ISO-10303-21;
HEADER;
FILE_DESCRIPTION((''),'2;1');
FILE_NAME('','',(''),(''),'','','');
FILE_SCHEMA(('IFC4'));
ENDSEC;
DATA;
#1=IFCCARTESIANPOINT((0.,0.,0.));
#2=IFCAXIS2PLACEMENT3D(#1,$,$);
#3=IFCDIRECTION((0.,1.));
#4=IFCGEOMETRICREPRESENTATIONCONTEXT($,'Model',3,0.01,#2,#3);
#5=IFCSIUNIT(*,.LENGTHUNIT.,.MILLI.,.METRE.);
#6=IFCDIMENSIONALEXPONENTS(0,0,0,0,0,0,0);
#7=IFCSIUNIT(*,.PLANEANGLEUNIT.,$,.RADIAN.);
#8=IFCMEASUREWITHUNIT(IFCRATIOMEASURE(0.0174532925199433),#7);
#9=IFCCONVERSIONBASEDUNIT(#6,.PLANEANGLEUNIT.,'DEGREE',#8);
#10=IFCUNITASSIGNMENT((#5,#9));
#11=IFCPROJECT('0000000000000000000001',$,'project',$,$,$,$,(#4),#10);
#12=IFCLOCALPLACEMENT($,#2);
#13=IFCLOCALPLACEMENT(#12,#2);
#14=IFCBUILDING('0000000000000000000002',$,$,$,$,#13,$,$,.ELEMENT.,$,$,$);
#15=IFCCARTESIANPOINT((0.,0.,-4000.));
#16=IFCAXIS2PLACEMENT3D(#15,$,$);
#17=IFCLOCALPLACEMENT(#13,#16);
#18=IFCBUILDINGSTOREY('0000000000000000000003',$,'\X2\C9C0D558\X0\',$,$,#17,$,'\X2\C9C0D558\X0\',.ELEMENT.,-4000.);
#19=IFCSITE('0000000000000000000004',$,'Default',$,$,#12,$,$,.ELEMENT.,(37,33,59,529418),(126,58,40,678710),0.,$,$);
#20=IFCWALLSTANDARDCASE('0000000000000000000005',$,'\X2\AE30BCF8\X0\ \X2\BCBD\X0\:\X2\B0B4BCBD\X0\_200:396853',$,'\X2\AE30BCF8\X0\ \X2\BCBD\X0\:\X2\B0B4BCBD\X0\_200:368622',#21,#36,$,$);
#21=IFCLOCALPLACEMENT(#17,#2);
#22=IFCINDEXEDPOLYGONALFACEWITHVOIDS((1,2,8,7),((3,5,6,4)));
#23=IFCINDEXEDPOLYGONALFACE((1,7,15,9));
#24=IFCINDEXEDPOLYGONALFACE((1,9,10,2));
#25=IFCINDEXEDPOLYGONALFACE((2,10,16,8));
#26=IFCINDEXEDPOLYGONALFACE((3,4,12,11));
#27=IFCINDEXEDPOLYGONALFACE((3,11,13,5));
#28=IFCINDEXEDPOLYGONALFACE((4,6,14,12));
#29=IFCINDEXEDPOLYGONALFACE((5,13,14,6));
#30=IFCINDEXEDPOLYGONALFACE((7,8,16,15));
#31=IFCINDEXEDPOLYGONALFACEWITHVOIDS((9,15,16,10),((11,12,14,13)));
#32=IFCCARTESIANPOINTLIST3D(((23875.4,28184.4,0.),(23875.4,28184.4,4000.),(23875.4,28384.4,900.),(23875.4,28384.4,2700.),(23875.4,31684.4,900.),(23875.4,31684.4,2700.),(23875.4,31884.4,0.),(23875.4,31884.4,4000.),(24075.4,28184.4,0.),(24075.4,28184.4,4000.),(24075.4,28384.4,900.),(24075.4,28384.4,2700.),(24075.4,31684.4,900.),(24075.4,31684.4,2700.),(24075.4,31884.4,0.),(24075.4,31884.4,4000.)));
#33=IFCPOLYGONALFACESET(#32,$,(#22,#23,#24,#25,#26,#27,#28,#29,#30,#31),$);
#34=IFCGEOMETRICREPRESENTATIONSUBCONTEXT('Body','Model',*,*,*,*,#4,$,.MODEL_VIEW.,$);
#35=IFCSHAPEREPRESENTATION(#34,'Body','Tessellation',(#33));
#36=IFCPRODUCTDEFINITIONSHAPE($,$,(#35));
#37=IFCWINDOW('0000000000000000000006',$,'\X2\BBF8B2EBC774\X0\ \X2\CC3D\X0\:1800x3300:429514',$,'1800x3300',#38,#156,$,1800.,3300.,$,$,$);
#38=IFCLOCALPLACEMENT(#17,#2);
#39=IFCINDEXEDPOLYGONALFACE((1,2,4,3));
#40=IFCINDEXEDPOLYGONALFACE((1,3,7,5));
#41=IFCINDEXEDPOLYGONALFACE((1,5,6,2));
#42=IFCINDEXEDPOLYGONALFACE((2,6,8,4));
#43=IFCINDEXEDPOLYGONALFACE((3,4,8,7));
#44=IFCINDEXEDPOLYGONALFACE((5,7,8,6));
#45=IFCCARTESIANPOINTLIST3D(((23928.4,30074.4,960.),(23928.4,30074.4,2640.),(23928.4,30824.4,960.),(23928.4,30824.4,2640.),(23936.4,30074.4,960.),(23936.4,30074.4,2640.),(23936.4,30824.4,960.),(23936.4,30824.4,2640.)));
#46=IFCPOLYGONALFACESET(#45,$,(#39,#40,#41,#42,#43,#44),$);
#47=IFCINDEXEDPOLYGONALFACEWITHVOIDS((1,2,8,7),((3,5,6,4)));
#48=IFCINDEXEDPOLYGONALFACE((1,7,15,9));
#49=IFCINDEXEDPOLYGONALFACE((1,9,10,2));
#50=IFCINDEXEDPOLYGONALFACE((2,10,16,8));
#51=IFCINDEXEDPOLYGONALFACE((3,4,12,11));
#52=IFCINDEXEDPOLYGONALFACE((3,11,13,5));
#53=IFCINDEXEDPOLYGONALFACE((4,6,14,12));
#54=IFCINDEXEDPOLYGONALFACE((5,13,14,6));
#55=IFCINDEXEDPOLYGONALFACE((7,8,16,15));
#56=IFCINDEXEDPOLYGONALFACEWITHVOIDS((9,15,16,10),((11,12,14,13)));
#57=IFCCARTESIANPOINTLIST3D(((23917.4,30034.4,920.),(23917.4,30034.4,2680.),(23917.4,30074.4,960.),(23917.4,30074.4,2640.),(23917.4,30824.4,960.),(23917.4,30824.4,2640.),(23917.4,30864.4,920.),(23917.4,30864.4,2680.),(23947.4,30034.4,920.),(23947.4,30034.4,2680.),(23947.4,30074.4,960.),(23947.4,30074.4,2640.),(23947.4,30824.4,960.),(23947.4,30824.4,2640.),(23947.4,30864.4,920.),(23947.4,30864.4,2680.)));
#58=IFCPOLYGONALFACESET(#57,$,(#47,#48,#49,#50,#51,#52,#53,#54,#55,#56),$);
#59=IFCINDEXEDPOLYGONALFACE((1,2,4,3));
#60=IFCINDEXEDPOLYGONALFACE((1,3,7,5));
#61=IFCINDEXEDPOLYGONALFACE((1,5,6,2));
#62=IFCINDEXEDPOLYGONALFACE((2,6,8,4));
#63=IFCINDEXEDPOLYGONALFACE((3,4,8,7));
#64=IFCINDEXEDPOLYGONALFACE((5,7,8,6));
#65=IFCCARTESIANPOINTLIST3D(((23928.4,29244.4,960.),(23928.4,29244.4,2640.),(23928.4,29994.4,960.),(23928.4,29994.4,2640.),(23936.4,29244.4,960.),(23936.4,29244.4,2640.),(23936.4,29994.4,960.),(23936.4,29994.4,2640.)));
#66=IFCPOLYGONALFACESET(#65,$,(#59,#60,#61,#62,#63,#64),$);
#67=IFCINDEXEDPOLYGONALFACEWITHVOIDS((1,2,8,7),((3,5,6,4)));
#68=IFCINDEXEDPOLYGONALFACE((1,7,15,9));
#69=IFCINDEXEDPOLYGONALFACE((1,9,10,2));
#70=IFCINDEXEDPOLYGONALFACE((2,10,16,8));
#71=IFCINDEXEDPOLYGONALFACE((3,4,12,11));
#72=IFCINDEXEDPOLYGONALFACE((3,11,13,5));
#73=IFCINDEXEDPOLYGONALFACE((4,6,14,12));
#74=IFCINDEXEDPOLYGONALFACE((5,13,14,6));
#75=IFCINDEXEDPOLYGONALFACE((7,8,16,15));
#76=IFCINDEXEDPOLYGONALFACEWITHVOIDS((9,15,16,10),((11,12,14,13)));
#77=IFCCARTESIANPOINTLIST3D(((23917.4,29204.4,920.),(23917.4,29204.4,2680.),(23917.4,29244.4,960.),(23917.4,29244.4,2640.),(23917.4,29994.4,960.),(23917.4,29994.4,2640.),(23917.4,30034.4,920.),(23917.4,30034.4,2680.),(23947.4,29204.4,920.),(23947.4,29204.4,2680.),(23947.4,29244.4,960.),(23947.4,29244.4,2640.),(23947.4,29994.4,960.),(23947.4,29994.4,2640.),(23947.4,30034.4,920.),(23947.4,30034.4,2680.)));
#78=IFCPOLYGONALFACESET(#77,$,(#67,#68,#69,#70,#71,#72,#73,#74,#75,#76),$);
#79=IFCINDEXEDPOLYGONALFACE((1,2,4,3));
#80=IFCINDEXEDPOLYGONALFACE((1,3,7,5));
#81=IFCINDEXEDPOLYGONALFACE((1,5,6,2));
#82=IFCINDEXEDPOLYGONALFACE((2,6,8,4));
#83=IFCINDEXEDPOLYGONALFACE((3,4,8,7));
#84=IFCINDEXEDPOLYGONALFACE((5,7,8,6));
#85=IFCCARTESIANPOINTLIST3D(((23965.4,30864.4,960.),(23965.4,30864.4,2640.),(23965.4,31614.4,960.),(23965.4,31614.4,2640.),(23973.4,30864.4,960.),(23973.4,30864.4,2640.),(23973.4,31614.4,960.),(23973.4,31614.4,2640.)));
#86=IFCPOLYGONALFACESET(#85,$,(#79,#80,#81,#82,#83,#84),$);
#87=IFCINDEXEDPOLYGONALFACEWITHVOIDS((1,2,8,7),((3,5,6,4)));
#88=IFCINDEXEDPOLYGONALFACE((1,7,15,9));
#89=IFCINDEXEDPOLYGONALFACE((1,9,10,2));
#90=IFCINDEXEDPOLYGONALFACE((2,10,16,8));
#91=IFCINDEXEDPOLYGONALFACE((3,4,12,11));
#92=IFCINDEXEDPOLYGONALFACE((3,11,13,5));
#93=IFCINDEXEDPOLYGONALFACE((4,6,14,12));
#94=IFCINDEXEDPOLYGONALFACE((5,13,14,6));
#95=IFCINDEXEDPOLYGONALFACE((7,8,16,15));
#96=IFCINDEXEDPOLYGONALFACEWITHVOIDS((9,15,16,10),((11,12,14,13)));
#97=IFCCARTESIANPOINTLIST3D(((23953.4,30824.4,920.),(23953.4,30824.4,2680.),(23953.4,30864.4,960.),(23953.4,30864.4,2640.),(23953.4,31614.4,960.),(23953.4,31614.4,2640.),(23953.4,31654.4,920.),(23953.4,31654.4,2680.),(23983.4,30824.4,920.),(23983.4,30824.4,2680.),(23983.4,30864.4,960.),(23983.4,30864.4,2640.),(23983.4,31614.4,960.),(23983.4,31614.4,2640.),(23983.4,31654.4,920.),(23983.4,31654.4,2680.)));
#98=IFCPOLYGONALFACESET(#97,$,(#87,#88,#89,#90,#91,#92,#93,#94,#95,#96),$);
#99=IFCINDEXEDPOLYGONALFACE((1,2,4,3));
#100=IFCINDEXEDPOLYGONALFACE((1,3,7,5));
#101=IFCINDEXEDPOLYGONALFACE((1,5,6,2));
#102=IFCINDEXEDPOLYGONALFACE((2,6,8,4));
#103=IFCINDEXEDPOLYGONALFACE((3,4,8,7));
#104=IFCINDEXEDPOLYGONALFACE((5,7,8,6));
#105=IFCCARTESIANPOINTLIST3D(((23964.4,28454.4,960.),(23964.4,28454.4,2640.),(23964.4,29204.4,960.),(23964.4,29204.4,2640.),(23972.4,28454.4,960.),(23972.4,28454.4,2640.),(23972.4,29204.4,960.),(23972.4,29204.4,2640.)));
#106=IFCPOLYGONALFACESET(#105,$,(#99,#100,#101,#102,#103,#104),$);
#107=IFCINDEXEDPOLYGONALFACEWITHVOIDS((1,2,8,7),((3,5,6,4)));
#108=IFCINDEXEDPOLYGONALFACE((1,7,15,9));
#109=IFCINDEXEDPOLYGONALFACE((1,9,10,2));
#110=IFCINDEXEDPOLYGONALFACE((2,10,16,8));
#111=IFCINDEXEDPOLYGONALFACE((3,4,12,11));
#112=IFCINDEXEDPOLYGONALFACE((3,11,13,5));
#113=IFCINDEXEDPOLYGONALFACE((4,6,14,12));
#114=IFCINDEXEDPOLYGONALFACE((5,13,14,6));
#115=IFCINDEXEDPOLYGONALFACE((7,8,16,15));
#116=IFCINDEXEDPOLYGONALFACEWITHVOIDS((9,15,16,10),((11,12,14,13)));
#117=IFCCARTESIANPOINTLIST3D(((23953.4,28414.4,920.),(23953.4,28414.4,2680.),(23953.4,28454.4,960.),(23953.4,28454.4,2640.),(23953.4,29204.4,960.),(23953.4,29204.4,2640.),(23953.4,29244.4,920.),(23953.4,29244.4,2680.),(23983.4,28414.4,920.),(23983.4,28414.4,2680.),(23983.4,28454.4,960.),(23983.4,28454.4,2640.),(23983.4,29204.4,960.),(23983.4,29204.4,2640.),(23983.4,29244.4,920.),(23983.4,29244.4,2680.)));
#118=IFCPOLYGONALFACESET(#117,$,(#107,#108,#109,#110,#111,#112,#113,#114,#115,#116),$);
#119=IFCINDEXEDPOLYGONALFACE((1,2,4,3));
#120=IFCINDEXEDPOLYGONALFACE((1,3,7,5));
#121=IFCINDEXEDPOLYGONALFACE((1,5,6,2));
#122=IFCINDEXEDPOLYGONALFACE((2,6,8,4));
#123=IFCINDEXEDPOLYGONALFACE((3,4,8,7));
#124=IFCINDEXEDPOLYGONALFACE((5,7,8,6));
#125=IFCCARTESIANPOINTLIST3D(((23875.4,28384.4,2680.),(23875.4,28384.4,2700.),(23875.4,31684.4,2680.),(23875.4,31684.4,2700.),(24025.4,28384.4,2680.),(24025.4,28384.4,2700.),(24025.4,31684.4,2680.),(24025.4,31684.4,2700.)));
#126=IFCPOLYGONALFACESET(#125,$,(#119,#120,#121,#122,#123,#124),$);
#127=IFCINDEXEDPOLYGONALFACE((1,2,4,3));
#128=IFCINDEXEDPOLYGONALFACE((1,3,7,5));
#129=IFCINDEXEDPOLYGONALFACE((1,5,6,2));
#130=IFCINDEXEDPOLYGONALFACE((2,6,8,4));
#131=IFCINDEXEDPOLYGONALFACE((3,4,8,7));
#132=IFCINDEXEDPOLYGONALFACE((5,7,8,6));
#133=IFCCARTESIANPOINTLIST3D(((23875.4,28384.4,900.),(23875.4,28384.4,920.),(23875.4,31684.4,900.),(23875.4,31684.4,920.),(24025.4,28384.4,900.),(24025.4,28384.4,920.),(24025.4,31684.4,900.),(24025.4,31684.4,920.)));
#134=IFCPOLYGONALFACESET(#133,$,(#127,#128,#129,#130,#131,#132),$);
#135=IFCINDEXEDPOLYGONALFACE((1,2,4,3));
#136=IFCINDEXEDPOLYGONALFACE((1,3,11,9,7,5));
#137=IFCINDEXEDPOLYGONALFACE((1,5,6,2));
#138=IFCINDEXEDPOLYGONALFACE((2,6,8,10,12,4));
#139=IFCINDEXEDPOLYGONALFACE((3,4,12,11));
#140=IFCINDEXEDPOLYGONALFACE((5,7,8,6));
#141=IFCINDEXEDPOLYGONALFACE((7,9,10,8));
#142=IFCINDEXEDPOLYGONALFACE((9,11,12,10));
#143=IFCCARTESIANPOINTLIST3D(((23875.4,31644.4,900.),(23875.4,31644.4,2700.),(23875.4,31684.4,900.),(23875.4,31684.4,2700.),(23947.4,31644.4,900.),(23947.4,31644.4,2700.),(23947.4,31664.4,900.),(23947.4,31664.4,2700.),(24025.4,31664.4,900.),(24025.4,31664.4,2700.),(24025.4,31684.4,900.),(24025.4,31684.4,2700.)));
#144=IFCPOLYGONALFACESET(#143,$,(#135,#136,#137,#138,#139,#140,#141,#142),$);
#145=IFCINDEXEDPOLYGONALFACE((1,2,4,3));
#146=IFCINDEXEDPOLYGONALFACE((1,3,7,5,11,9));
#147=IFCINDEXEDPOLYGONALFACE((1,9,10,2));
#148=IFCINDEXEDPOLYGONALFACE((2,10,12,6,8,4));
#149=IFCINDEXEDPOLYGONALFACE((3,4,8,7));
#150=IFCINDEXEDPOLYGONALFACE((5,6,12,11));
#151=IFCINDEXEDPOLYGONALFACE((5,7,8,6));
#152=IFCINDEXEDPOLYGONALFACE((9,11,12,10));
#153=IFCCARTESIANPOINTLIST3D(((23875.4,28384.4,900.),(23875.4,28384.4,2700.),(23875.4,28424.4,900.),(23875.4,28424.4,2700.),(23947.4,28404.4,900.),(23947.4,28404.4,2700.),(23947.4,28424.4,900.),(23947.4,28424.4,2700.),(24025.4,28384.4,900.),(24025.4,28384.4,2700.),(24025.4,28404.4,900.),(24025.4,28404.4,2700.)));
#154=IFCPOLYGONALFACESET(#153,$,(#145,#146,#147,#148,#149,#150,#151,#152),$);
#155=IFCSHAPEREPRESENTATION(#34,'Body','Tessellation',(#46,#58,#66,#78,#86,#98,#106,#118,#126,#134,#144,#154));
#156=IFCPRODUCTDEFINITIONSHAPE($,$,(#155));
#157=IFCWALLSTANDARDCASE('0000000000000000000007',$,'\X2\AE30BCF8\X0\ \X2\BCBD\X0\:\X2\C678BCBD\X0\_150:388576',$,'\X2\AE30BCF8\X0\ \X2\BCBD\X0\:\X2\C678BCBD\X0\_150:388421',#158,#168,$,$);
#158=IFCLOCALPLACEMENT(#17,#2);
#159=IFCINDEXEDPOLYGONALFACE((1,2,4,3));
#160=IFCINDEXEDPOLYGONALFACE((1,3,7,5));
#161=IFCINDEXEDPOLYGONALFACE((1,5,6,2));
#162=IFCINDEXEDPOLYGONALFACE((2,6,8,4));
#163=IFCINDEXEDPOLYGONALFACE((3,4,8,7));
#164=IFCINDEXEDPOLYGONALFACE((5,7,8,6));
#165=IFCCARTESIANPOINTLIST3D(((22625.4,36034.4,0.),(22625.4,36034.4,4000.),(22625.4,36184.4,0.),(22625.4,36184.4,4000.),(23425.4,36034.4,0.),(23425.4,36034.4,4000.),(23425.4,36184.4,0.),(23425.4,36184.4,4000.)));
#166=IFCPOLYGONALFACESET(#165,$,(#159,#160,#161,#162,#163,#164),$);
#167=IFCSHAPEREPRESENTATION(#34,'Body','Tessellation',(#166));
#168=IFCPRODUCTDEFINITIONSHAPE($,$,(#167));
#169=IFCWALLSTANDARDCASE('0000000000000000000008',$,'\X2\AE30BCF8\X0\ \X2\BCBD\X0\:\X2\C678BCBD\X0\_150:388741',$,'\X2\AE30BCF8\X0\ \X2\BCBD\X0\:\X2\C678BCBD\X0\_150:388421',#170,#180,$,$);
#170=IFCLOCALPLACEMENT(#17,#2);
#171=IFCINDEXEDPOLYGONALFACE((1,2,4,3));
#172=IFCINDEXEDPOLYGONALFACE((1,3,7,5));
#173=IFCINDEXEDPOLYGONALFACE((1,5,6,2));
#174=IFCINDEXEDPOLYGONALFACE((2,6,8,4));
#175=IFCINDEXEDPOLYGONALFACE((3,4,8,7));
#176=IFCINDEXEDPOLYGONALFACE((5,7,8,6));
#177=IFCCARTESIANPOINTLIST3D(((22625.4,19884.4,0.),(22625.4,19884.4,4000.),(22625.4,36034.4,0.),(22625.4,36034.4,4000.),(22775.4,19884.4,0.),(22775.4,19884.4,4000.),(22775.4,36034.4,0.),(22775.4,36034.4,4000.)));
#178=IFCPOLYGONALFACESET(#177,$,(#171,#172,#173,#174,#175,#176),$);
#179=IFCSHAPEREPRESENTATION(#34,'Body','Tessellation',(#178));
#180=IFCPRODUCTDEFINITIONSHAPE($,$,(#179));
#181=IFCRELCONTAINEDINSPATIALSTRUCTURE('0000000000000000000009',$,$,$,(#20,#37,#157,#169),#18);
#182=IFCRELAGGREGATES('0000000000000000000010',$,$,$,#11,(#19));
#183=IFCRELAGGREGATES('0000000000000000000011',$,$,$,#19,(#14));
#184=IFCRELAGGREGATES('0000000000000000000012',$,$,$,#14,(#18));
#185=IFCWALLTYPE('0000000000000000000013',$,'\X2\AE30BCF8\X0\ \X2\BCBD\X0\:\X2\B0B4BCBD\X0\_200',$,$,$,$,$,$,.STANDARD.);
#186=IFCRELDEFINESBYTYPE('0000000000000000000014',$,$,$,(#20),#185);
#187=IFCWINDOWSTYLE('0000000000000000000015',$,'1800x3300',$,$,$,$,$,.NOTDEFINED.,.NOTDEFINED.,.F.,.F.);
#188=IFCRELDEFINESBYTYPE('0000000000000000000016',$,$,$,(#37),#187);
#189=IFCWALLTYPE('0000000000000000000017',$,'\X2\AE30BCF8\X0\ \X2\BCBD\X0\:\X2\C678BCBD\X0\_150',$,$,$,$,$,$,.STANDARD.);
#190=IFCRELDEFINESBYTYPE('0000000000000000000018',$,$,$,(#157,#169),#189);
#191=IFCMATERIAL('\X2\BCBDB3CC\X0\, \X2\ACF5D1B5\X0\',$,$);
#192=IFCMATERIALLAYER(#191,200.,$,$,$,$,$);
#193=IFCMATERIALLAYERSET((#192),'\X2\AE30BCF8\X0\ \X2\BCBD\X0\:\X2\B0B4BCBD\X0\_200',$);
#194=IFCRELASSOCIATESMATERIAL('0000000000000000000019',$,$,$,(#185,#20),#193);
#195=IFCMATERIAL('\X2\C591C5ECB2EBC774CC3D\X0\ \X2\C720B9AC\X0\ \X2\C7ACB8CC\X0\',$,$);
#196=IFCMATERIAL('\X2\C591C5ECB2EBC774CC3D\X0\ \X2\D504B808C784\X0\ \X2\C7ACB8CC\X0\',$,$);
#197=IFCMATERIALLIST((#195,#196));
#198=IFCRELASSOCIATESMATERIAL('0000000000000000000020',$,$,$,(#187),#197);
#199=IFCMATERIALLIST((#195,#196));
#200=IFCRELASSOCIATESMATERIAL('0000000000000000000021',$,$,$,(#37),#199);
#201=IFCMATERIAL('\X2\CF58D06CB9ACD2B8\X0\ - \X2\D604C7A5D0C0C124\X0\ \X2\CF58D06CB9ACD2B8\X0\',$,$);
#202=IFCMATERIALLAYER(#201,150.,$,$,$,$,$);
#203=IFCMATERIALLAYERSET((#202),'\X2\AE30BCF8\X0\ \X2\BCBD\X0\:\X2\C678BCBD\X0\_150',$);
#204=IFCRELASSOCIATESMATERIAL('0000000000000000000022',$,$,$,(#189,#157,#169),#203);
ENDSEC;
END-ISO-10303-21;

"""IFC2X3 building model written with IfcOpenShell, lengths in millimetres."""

from ifc_helpers import new_model, entity, si_unit, converted_unit, direction, frame, frame_2d, origin, origin_2d_with_axis, place, context, subcontext, project, spatial, polyline, rectangle, outline, extrude, source, transform, mapped, material, material_list, layer, layer_set, layer_usage, type_object, type_shapes, element, fill, save


model = new_model("IFC2X3")

# Units and contexts
model_context = context("Model", 3, precision=0.01, world=origin(), true_north=direction((0.0, 1.0)))
body_context = subcontext(model_context, "Body", "Model", "MODEL_VIEW")
ifc_project = project(units=[si_unit("LENGTHUNIT", "METRE", prefix="MILLI"), converted_unit("PLANEANGLEUNIT", "DEGREE", entity("IfcRatioMeasure", 0.0174532925199433), si_unit("PLANEANGLEUNIT", "RADIAN"), dimensions=[0, 0, 0, 0, 0, 0, 0])], contexts=[model_context])

# Site, building, storey
site_placement = place(None, origin())
site = spatial("IfcSite", under=ifc_project, at=site_placement, Name="Default", CompositionType="ELEMENT", RefLatitude=(37, 33, 59, 529418), RefLongitude=(126, 58, 40, 678710), RefElevation=0.0)
building_placement = place(site_placement, origin())
building = spatial("IfcBuilding", under=site, at=building_placement, CompositionType="ELEMENT")
storey_placement = place(building_placement, frame((0.0, 0.0, -4000.0)))
storey = spatial("IfcBuildingStorey", under=building, at=storey_placement, Name="지하", LongName="지하", CompositionType="ELEMENT", Elevation=-4000.0)

# Shared definitions
ifc_material_1 = material(Name="콘크리트 - 현장타설 콘크리트")

# Wall, opening, window
ifc_material_2 = material(Name="벽돌, 공통")
ifc_layer_1 = layer(ifc_material_2, 200.0)
ifc_layer_set_1 = layer_set([ifc_layer_1], Name="기본 벽:내벽_200")
wall_type_1 = type_object("IfcWallType", Name="기본 벽:내벽_200", PredefinedType="STANDARD", material=ifc_layer_set_1)
ifc_material_3 = material(Name="양여닫이창 유리 재료")
ifc_material_4 = material(Name="양여닫이창 프레임 재료")
ifc_material_list_1 = material_list([ifc_material_3, ifc_material_4])
window_style = type_object("IfcWindowStyle", Name="1800x3300", ConstructionType="NOTDEFINED", OperationType="NOTDEFINED", ParameterTakesPrecedence=False, Sizeable=False, material=ifc_material_list_1)
shared_shape_1 = source(origin(), body_context, "Body", "SweptSolid", [
    extrude(rectangle(XDim=8.0, YDim=750.0, at=frame_2d((0.0, 0.0), x_axis=(1.0, 0.0))), frame((2065.0, 143.0, 60.0), z_axis=(0.0, 0.0, 1.0), x_axis=(0.0, 1.0, 0.0)), (0.0, 0.0, 1.0), 1680.0),
    extrude(outline(polyline([(-880.0, -415.0), (880.0, -415.0), (880.0, 415.0), (-880.0, 415.0), (-880.0, -415.0)]), holes=[polyline([(840.0, -375.0), (-840.0, -375.0), (-840.0, 375.0), (840.0, 375.0), (840.0, -375.0)])]), frame((2065.0, 128.0, 900.0), z_axis=(0.0, 1.0, 0.0), x_axis=(0.0, 0.0, -1.0)), (0.0, 0.0, 1.0), 30.0),
    extrude(rectangle(XDim=8.0, YDim=750.0, at=frame_2d((0.0, 0.0), x_axis=(1.0, 0.0))), frame((1235.0, 143.0, 60.0), z_axis=(0.0, 0.0, 1.0), x_axis=(0.0, 1.0, 0.0)), (0.0, 0.0, 1.0), 1680.0),
    extrude(outline(polyline([(-880.0, -415.0), (880.0, -415.0), (880.0, 415.0), (-880.0, 415.0), (-880.0, -415.0)]), holes=[polyline([(840.0, -375.0), (-840.0, -375.0), (-840.0, 375.0), (840.0, 375.0), (840.0, -375.0)])]), frame((1235.0, 128.0, 900.0), z_axis=(0.0, 1.0, 0.0), x_axis=(0.0, 0.0, -1.0)), (0.0, 0.0, 1.0), 30.0),
    extrude(rectangle(XDim=8.0, YDim=750.0, at=frame_2d((0.0, 0.0), x_axis=(1.0, 0.0))), frame((2855.0, 106.0, 60.0), z_axis=(0.0, 0.0, 1.0), x_axis=(0.0, 1.0, 0.0)), (0.0, 0.0, 1.0), 1680.0),
    extrude(outline(polyline([(-880.0, -415.0), (880.0, -415.0), (880.0, 415.0), (-880.0, 415.0), (-880.0, -415.0)]), holes=[polyline([(840.0, -375.0), (-840.0, -375.0), (-840.0, 375.0), (840.0, 375.0), (840.0, -375.0)])]), frame((2855.0, 92.0, 900.0), z_axis=(0.0, 1.0, 0.0), x_axis=(0.0, 0.0, -1.0)), (0.0, 0.0, 1.0), 30.0),
    extrude(rectangle(XDim=8.0, YDim=750.0, at=origin_2d_with_axis()), frame((445.0, 107.0, 60.0), z_axis=(0.0, 0.0, 1.0), x_axis=(0.0, 1.0, 0.0)), (0.0, 0.0, 1.0), 1680.0),
    extrude(outline(polyline([(-880.0, -415.0), (880.0, -415.0), (880.0, 415.0), (-880.0, 415.0), (-880.0, -415.0)]), holes=[polyline([(840.0, -375.0), (-840.0, -375.0), (-840.0, 375.0), (840.0, 375.0), (840.0, -375.0)])]), frame((445.0, 92.0, 900.0), z_axis=(0.0, 1.0, 0.0), x_axis=(0.0, 0.0, -1.0)), (0.0, 0.0, 1.0), 30.0),
    extrude(rectangle(XDim=3300.0, YDim=150.0, at=origin_2d_with_axis()), frame((1650.0, 125.0, 1780.0), z_axis=(0.0, 0.0, 1.0), x_axis=(-1.0, 0.0, 0.0)), (0.0, 0.0, 1.0), 20.0),
    extrude(rectangle(XDim=3300.0, YDim=150.0, at=origin_2d_with_axis()), frame((1650.0, 125.0, 0.0), z_axis=(0.0, 0.0, 1.0), x_axis=(-1.0, 0.0, 0.0)), (0.0, 0.0, 1.0), 20.0),
    extrude(outline(polyline([(-74.0, -20.0), (-2.0, -20.0), (-2.0, 0.0), (76.0, 0.0), (76.0, 20.0), (-74.0, 20.0), (-74.0, -20.0)])), frame((3280.0, 126.0, 0.0), z_axis=(0.0, 0.0, 1.0), x_axis=(0.0, -1.0, 0.0)), (0.0, 0.0, 1.0), 1800.0),
    extrude(outline(polyline([(-20.0, -74.0), (20.0, -74.0), (20.0, 76.0), (0.0, 76.0), (0.0, -2.0), (-20.0, -2.0), (-20.0, -74.0)])), frame((20.0, 126.0, 0.0), z_axis=(0.0, 0.0, 1.0), x_axis=(-1.0, 0.0, 0.0)), (0.0, 0.0, 1.0), 1800.0),
])
type_shapes(window_style, [shared_shape_1])
ifc_layer_usage_1 = layer_usage(ifc_layer_set_1, "AXIS2", "NEGATIVE", 100.0)
wall_1_placement = place(storey_placement, frame((23975.4, 31884.4, 0.0), z_axis=(0.0, 0.0, 1.0), x_axis=(0.0, -1.0, 0.0)))
wall_1 = element("IfcWallStandardCase", 1, at=wall_1_placement, inside=storey, type_object=wall_type_1, material=ifc_layer_usage_1, Name="기본 벽:내벽_200:396853", ObjectType="기본 벽:내벽_200:368622", context=body_context, shape_type="SweptSolid", body=[
    extrude(rectangle(XDim=3700.0, YDim=200.0, at=frame_2d((1850.0, 0.0), x_axis=(-1.0, 0.0))), origin(), (0.0, 0.0, 1.0), 4000.0),
])
opening_1_placement = place(wall_1_placement, frame((3500.0, 100.0, 900.0)))
opening_1 = element("IfcOpeningElement", 2, at=opening_1_placement, cuts=wall_1, ObjectType="Opening", context=body_context, shape_type="SweptSolid", body=[
    extrude(rectangle(XDim=1800.0, YDim=3300.0, at=frame_2d((900.0, 1650.0), x_axis=(1.0, 0.0))), frame((0.0, 0.0, 0.0), z_axis=(0.0, -1.0, 0.0), x_axis=(0.0, 0.0, 1.0)), (0.0, 0.0, 1.0), 200.0),
])
ifc_material_list_2 = material_list([ifc_material_3, ifc_material_4])
window_1_placement = place(opening_1_placement, frame((0.0, 0.0, 0.0), z_axis=(0.0, 0.0, 1.0), x_axis=(-1.0, 0.0, 0.0)))
window_1 = element("IfcWindow", 3, at=window_1_placement, inside=storey, type_object=window_style, material=ifc_material_list_2, Name="미닫이 창:1800x3300:429514", ObjectType="1800x3300", OverallHeight=1800.0, OverallWidth=3300.0, context=body_context, shape_type="MappedRepresentation", body=[
    mapped(shared_shape_1, transform((0.0, 0.0, 0.0), scale=1.0)),
])
fill(opening_1, window_1)

# Walls
ifc_layer_2 = layer(ifc_material_1, 150.0)
ifc_layer_set_2 = layer_set([ifc_layer_2], Name="기본 벽:외벽_150")
ifc_layer_usage_2 = layer_usage(ifc_layer_set_2, "AXIS2", "NEGATIVE", 75.0)
wall_type_2 = type_object("IfcWallType", Name="기본 벽:외벽_150", PredefinedType="STANDARD", material=ifc_layer_set_2)
wall_2_placement = place(storey_placement, frame((23425.4, 36109.4, 0.0), z_axis=(0.0, 0.0, 1.0), x_axis=(-1.0, 0.0, 0.0)))
element("IfcWallStandardCase", 4, at=wall_2_placement, inside=storey, type_object=wall_type_2, material=ifc_layer_usage_2, Name="기본 벽:외벽_150:388576", ObjectType="기본 벽:외벽_150:388421", context=body_context, shape_type="SweptSolid", body=[
    extrude(rectangle(XDim=800.0, YDim=150.0, at=frame_2d((400.0, 0.0), x_axis=(-1.0, 0.0))), origin(), (0.0, 0.0, 1.0), 4000.0),
])
ifc_layer_usage_3 = layer_usage(ifc_layer_set_2, "AXIS2", "NEGATIVE", 75.0)
wall_3_placement = place(storey_placement, frame((22700.4, 36034.4, 0.0), z_axis=(0.0, 0.0, 1.0), x_axis=(0.0, -1.0, 0.0)))
element("IfcWallStandardCase", 5, at=wall_3_placement, inside=storey, type_object=wall_type_2, material=ifc_layer_usage_3, Name="기본 벽:외벽_150:388741", ObjectType="기본 벽:외벽_150:388421", context=body_context, shape_type="SweptSolid", body=[
    extrude(rectangle(XDim=16150.0, YDim=150.0, at=frame_2d((8075.0, 0.0), x_axis=(-1.0, 0.0))), origin(), (0.0, 0.0, 1.0), 4000.0),
])

save(model, "model.ifc")
